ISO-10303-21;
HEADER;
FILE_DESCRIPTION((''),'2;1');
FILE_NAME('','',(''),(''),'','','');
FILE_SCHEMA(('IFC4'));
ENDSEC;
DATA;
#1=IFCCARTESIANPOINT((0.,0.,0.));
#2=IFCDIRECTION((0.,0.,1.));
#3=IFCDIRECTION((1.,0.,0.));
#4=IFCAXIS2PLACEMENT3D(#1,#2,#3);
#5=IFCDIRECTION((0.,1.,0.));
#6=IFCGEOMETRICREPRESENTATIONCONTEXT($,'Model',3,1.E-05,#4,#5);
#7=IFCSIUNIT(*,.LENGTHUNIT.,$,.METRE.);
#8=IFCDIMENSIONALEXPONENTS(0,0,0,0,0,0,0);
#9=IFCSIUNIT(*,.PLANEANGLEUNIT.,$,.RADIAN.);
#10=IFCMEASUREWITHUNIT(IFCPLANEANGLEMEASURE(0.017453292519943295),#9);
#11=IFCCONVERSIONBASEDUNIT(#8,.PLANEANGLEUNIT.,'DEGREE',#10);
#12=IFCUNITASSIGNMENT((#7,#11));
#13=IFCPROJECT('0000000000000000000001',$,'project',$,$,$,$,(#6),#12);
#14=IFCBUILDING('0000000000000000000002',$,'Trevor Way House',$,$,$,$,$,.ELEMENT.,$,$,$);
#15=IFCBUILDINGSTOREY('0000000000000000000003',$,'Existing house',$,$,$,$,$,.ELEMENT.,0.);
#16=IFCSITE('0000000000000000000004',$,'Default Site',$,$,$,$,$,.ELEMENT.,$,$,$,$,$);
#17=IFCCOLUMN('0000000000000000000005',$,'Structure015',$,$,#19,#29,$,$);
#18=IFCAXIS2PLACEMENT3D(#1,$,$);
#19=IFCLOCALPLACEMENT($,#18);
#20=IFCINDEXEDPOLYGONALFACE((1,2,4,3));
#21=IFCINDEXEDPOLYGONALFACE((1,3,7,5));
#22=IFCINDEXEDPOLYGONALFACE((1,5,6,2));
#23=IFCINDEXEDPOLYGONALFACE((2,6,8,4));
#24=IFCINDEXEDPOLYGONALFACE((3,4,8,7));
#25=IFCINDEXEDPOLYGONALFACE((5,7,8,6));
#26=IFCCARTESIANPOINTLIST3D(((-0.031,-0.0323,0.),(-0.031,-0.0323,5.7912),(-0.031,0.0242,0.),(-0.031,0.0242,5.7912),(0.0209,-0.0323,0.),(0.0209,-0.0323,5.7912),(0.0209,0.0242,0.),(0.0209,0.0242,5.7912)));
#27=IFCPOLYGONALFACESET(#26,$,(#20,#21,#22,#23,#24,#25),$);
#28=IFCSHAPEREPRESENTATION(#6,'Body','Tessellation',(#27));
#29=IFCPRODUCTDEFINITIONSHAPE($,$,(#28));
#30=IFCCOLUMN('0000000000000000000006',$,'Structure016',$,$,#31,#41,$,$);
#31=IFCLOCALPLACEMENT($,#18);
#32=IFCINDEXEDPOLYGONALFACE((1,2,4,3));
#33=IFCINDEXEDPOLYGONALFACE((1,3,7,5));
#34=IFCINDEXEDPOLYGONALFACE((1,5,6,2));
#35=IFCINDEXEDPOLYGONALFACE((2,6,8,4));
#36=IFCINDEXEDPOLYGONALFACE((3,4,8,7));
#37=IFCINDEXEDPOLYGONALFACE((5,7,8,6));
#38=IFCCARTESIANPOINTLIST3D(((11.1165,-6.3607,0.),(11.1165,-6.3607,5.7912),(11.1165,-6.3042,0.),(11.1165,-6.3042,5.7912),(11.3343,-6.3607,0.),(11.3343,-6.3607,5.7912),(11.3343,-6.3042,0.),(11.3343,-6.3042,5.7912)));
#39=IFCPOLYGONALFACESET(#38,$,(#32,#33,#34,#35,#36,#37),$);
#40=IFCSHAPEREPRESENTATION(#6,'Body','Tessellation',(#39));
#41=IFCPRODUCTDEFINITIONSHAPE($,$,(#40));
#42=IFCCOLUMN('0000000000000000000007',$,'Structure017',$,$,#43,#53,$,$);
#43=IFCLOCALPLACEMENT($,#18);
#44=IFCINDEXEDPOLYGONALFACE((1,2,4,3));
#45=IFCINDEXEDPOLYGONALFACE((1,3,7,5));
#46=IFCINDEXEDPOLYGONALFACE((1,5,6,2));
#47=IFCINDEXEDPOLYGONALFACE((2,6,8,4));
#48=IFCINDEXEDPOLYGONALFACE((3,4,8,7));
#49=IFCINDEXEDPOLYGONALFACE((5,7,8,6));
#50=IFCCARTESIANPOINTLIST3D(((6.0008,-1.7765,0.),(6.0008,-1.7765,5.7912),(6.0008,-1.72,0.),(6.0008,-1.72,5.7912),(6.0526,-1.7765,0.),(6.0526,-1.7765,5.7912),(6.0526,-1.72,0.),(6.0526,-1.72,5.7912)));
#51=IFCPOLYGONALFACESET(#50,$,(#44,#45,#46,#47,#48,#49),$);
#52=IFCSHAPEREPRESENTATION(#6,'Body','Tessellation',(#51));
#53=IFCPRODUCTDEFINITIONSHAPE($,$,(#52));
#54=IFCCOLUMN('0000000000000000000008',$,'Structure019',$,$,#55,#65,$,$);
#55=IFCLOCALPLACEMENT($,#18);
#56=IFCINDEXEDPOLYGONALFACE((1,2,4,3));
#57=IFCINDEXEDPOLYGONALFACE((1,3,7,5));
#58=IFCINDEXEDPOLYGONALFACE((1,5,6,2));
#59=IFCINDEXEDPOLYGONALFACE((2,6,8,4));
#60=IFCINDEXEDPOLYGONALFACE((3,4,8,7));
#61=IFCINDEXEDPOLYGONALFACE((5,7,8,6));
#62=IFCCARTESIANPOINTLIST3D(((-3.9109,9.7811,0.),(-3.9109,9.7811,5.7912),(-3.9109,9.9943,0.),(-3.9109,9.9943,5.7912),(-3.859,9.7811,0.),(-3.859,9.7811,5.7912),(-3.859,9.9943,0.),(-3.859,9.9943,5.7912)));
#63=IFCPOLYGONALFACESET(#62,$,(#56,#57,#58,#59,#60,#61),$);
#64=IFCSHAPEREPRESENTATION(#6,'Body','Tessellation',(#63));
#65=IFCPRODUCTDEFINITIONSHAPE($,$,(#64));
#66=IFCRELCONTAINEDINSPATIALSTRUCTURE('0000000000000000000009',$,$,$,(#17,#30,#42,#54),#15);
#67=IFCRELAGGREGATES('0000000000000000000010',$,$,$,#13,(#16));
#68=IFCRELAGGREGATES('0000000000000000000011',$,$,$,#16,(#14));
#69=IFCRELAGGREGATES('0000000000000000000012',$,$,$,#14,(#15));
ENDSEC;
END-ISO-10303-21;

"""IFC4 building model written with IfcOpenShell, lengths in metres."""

from ifc_helpers import new_model, entity, si_unit, converted_unit, direction, frame, origin_with_axes, place, context, project, spatial, polyline, outline, extrude, source, transform, mapped, element, save


model = new_model("IFC4")

# Units and contexts
model_context = context("Model", 3, precision=1e-05, world=origin_with_axes(), true_north=direction((0.0, 1.0, 0.0)))
ifc_project = project(units=[si_unit("LENGTHUNIT", "METRE"), converted_unit("PLANEANGLEUNIT", "DEGREE", entity("IfcPlaneAngleMeasure", 0.017453292519943295), si_unit("PLANEANGLEUNIT", "RADIAN"), dimensions=[0, 0, 0, 0, 0, 0, 0])], contexts=[model_context])

# Site, building, storey
site = spatial("IfcSite", under=ifc_project, Name="Default Site", CompositionType="ELEMENT")
building = spatial("IfcBuilding", under=site, Name="Trevor Way House", CompositionType="ELEMENT")
storey = spatial("IfcBuildingStorey", under=building, Name="Existing house", CompositionType="ELEMENT", Elevation=0.0)

# Columns
placement = place(None, origin_with_axes())
shared_shape_1 = source(origin_with_axes(), model_context, "Body", "SweptSolid", [
    extrude(outline(polyline([(-0.0259, -0.0282), (0.0259, -0.0282), (0.0259, 0.0282), (-0.0259, 0.0282), (-0.0259, -0.0282)])), frame((-0.005, -0.004, 0.0), z_axis=(0.0, 0.0, 1.0), x_axis=(1.0, 0.0, 0.0)), (0.0, 0.0, 1.0), 5.7912),
])
element("IfcColumn", 1, at=placement, inside=storey, Name="Structure015", context=model_context, shape_type="MappedRepresentation", body=[
    mapped(shared_shape_1, transform((0.0, 0.0, 0.0), x_axis=(1.0, 0.0, 0.0), y_axis=(0.0, 1.0, 0.0), z_axis=(0.0, 0.0, 1.0), scale=1.0)),
])
shared_shape_2 = source(origin_with_axes(), model_context, "Body", "SweptSolid", [
    extrude(outline(polyline([(-0.1089, -0.0282), (0.1089, -0.0282), (0.1089, 0.0282), (-0.1089, 0.0282), (-0.1089, -0.0282)])), frame((11.2254, -6.3324, 0.0), z_axis=(0.0, 0.0, 1.0), x_axis=(1.0, 0.0, 0.0)), (0.0, 0.0, 1.0), 5.7912),
])
element("IfcColumn", 2, at=placement, inside=storey, Name="Structure016", context=model_context, shape_type="MappedRepresentation", body=[
    mapped(shared_shape_2, transform((0.0, 0.0, 0.0), x_axis=(1.0, 0.0, 0.0), y_axis=(0.0, 1.0, 0.0), z_axis=(0.0, 0.0, 1.0), scale=1.0)),
])
shared_shape_3 = source(origin_with_axes(), model_context, "Body", "SweptSolid", [
    extrude(outline(polyline([(-0.0259, -0.0282), (0.0259, -0.0282), (0.0259, 0.0282), (-0.0259, 0.0282), (-0.0259, -0.0282)])), frame((6.0267, -1.7483, 0.0), z_axis=(0.0, 0.0, 1.0), x_axis=(1.0, 0.0, 0.0)), (0.0, 0.0, 1.0), 5.7912),
])
element("IfcColumn", 3, at=placement, inside=storey, Name="Structure017", context=model_context, shape_type="MappedRepresentation", body=[
    mapped(shared_shape_3, transform((0.0, 0.0, 0.0), x_axis=(1.0, 0.0, 0.0), y_axis=(0.0, 1.0, 0.0), z_axis=(0.0, 0.0, 1.0), scale=1.0)),
])
shared_shape_4 = source(origin_with_axes(), model_context, "Body", "SweptSolid", [
    extrude(outline(polyline([(-0.0259, -0.1066), (0.0259, -0.1066), (0.0259, 0.1066), (-0.0259, 0.1066), (-0.0259, -0.1066)])), frame((-3.8849, 9.8877, 0.0), z_axis=(0.0, 0.0, 1.0), x_axis=(1.0, 0.0, 0.0)), (0.0, 0.0, 1.0), 5.7912),
])
element("IfcColumn", 4, at=placement, inside=storey, Name="Structure019", context=model_context, shape_type="MappedRepresentation", body=[
    mapped(shared_shape_4, transform((0.0, 0.0, 0.0), x_axis=(1.0, 0.0, 0.0), y_axis=(0.0, 1.0, 0.0), z_axis=(0.0, 0.0, 1.0), scale=1.0)),
])

save(model, "model.ifc")
